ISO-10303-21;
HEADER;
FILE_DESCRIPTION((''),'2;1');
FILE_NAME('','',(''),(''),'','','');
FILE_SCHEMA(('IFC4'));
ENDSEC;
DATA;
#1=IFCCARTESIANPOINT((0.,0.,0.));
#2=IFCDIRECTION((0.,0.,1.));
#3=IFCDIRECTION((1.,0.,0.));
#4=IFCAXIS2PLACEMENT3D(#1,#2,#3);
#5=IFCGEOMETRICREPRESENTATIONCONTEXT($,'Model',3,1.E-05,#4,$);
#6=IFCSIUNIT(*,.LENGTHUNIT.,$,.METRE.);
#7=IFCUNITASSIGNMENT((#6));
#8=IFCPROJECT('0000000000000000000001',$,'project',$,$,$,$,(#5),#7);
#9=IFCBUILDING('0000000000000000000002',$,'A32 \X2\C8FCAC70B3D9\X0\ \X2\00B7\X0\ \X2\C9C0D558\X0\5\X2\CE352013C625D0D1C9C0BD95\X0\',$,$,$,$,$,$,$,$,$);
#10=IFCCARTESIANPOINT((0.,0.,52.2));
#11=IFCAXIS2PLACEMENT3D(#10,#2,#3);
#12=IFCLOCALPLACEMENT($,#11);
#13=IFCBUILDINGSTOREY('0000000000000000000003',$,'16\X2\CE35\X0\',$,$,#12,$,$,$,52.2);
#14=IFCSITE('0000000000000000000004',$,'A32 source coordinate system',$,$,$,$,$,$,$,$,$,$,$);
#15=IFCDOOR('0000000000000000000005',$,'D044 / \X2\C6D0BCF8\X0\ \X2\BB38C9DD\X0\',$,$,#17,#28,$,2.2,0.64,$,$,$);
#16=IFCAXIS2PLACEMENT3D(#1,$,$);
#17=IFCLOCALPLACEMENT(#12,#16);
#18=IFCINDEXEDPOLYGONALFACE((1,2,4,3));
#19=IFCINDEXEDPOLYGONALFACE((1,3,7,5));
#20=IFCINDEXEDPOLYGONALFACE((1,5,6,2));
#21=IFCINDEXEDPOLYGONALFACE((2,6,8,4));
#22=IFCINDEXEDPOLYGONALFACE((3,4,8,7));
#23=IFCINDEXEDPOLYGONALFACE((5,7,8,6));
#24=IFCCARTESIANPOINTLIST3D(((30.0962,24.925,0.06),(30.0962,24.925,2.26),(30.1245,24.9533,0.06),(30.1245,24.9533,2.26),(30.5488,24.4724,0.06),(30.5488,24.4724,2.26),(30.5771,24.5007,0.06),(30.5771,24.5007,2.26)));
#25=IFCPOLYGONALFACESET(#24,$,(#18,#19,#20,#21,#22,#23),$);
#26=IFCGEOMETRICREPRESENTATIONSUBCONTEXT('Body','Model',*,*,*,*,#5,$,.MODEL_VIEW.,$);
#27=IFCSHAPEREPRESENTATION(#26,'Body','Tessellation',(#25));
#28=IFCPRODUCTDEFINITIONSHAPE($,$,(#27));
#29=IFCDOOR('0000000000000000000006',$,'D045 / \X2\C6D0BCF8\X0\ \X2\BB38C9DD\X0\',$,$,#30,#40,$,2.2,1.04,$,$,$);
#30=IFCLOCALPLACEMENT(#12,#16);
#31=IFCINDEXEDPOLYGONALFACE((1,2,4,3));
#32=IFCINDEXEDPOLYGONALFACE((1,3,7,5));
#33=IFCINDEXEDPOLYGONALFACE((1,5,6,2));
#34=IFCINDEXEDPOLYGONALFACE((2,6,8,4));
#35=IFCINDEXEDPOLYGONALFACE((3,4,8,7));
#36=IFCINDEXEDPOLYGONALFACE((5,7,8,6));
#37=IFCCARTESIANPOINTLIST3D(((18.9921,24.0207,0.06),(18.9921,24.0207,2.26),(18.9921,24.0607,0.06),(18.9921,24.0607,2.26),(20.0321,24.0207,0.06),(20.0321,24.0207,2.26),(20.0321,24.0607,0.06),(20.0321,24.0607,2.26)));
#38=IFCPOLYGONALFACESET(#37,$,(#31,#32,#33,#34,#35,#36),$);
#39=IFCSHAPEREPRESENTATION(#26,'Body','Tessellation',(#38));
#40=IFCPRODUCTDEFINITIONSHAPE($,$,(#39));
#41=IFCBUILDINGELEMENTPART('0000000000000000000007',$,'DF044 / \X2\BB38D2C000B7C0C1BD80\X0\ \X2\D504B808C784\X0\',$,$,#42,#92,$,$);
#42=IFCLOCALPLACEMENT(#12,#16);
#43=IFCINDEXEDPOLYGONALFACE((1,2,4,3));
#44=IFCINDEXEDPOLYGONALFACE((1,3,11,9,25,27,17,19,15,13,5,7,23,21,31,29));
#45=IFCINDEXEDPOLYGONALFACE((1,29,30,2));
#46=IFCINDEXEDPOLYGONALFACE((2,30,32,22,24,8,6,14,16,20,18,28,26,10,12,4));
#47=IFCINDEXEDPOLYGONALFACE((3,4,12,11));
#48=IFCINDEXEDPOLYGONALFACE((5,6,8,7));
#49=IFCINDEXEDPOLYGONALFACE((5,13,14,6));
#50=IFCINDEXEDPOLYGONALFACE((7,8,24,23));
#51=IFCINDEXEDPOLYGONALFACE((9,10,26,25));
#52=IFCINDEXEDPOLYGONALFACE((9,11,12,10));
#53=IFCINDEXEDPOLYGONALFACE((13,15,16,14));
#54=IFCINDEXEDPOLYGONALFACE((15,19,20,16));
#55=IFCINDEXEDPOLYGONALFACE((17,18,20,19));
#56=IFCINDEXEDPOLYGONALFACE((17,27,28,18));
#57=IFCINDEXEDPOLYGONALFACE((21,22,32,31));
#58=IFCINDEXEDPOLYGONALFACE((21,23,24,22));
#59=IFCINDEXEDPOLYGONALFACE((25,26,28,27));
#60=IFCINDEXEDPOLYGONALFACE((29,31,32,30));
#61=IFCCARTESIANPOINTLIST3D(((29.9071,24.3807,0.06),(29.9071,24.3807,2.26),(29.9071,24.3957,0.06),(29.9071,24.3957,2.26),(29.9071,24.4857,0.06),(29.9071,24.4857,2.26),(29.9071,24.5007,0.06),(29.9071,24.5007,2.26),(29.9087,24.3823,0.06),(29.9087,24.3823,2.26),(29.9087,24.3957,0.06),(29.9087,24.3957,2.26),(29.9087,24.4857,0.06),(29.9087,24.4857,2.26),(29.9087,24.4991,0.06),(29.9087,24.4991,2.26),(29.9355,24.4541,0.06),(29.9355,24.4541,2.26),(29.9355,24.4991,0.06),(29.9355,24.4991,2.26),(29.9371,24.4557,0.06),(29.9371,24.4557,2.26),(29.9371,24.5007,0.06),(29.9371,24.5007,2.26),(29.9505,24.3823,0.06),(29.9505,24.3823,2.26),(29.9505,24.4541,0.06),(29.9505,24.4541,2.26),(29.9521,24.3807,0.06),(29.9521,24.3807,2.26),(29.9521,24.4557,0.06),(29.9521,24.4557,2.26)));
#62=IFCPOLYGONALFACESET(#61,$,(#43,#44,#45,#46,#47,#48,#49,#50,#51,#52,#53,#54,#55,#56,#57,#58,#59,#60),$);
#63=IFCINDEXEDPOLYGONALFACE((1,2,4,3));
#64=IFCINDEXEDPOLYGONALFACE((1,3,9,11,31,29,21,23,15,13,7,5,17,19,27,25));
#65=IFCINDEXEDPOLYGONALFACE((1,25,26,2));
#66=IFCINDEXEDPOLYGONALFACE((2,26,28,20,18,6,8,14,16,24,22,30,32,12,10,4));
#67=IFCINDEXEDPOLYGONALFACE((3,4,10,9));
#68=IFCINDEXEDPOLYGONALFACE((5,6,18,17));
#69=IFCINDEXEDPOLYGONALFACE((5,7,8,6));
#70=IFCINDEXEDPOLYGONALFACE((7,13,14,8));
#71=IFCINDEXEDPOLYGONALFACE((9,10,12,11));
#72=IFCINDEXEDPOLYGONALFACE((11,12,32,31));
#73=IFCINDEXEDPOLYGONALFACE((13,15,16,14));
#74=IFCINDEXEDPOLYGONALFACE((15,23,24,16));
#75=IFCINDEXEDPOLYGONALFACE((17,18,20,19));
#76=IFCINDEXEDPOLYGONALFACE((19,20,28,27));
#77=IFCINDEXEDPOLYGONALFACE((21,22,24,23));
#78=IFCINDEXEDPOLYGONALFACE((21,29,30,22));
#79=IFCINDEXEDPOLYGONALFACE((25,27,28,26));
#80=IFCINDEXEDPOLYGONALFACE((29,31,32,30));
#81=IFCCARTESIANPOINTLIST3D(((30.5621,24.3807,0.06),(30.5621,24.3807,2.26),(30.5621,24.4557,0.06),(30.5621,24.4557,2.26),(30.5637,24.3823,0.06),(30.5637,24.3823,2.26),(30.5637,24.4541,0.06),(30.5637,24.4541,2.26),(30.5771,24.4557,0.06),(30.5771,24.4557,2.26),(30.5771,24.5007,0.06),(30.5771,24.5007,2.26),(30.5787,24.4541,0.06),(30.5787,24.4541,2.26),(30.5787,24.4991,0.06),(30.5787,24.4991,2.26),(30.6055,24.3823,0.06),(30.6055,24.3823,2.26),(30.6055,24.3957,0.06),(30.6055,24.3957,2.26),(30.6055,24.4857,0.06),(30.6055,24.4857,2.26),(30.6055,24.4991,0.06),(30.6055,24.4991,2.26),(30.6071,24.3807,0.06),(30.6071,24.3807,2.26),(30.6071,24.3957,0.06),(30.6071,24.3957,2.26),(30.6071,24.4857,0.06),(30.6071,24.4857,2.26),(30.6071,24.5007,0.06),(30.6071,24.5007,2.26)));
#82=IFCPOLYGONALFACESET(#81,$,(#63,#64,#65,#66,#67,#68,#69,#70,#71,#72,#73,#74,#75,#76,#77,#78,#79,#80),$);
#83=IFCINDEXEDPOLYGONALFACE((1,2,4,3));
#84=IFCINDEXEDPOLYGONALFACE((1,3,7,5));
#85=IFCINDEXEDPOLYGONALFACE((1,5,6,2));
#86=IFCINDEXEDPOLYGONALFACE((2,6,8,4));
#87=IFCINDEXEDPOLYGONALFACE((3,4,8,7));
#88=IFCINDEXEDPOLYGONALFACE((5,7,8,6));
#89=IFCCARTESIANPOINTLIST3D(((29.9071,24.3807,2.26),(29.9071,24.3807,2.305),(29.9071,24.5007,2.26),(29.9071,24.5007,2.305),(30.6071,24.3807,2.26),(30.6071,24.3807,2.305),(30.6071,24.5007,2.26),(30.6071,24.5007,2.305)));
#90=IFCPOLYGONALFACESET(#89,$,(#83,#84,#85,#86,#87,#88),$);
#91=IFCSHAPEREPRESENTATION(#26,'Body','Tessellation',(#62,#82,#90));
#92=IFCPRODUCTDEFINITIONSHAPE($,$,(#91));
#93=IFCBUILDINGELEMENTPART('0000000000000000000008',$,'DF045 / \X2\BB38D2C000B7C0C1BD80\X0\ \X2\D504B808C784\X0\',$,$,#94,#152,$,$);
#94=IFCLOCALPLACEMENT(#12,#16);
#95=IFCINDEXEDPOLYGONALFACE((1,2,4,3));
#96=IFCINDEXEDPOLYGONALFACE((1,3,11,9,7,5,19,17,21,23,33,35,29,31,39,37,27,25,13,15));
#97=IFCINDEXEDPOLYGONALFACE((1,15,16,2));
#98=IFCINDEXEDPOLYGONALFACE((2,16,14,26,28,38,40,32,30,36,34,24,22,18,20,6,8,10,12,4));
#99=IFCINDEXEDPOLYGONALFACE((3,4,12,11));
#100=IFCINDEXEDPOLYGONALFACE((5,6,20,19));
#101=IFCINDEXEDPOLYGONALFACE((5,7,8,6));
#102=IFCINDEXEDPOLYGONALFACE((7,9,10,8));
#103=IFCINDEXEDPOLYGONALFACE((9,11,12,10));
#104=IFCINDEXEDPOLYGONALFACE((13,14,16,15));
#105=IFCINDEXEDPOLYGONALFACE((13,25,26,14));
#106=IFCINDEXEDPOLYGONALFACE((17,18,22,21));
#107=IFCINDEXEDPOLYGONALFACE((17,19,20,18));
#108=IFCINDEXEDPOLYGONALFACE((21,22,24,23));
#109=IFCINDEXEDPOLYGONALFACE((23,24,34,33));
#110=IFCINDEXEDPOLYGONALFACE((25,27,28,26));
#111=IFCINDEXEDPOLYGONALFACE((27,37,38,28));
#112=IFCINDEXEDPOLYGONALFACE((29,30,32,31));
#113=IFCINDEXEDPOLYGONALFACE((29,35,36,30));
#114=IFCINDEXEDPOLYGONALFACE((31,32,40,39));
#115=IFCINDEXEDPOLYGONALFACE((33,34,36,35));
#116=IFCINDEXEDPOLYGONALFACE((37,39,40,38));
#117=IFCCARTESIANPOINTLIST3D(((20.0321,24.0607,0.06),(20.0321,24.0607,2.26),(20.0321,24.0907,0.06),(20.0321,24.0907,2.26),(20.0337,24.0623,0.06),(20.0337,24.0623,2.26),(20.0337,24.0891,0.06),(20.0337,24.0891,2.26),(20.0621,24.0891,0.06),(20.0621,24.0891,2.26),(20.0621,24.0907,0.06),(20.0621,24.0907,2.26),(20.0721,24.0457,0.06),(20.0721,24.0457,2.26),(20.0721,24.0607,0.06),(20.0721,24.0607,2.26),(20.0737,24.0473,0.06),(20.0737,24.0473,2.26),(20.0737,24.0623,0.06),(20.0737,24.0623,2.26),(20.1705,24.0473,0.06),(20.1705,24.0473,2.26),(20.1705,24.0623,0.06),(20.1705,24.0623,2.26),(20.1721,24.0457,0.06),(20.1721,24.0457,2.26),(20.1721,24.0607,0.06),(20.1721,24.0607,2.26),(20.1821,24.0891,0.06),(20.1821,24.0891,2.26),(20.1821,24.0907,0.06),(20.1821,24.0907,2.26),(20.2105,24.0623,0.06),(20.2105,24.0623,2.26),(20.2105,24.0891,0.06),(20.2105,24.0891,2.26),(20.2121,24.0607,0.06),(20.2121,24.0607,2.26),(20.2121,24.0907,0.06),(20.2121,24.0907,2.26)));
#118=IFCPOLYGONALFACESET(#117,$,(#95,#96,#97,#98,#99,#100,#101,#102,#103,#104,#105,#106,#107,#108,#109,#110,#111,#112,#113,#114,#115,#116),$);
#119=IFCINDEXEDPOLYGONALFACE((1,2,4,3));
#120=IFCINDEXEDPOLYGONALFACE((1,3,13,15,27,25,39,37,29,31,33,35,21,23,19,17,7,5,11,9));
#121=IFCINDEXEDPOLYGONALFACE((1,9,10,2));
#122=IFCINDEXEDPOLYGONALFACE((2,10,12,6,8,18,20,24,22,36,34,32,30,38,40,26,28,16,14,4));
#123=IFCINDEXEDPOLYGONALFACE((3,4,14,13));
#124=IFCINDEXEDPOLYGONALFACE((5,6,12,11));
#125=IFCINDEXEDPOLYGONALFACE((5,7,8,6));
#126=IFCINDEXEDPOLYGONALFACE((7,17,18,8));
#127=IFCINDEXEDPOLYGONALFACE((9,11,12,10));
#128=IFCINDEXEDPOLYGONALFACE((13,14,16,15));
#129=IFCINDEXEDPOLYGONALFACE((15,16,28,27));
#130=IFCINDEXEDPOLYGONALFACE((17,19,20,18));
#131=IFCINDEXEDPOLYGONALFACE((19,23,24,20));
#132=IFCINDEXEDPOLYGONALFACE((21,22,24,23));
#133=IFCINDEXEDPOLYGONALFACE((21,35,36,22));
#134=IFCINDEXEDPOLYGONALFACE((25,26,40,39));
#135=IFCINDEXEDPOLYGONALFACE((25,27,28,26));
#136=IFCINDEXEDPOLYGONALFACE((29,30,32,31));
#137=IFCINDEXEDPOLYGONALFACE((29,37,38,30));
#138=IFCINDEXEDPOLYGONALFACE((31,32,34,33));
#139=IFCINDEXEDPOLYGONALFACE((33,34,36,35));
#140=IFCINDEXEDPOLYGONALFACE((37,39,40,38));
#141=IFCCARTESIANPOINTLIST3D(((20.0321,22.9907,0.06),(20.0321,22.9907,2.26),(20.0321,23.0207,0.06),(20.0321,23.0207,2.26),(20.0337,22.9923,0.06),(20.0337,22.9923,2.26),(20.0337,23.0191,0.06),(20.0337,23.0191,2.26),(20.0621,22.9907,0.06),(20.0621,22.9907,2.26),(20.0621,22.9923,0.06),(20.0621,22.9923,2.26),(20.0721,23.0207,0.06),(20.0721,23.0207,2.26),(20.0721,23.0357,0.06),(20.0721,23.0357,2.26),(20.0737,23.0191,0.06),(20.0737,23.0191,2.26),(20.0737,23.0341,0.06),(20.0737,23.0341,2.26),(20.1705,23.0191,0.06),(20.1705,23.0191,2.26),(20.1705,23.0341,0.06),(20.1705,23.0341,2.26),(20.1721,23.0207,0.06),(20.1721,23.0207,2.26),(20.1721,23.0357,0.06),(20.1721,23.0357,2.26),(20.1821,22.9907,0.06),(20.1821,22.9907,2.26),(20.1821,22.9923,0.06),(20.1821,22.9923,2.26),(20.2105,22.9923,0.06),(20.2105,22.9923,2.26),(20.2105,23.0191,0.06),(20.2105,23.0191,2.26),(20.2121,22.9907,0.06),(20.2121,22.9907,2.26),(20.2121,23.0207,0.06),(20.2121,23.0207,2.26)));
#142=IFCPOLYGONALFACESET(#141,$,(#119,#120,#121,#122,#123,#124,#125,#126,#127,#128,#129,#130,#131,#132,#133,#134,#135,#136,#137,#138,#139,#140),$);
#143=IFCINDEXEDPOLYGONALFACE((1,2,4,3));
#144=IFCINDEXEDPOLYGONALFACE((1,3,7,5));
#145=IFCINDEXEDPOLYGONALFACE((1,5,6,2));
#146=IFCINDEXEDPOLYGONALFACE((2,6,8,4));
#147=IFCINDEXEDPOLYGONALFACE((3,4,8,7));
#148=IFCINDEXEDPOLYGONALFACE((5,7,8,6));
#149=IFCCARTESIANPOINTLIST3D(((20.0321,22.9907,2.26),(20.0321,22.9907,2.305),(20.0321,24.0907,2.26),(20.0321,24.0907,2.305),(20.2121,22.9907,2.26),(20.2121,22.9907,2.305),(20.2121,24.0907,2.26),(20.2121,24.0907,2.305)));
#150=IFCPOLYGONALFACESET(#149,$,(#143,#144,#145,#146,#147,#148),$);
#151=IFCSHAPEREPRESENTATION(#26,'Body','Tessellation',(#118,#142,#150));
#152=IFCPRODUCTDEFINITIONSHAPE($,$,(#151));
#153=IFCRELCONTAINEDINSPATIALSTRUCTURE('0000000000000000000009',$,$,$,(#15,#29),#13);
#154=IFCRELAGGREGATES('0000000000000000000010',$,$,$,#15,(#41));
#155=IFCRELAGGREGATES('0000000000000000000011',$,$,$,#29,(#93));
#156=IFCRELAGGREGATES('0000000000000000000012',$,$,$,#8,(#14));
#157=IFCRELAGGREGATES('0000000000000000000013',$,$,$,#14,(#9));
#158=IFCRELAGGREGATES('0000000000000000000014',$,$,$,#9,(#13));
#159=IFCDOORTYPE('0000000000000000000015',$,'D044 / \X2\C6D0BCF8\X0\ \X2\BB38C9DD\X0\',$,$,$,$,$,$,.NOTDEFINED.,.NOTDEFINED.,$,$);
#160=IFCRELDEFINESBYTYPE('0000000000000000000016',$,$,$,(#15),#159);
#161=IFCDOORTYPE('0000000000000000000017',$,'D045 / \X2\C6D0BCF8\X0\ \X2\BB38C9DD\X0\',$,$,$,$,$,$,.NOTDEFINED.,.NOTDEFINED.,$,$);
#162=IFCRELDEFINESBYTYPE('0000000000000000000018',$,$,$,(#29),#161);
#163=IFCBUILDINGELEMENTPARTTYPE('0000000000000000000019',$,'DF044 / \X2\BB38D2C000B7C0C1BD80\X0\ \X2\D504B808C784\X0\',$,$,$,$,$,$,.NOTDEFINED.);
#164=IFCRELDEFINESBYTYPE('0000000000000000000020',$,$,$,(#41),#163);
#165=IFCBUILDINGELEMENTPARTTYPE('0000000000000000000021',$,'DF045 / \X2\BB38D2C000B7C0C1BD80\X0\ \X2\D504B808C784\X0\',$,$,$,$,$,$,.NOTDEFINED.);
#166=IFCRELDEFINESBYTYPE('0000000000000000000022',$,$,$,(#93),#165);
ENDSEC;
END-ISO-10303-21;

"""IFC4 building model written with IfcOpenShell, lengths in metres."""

from ifc_helpers import new_model, si_unit, frame, origin, origin_with_axes, place, context, subcontext, project, spatial, polyline, outline, extrude, source, transform, mapped, type_object, type_shapes, element, aggregate, save


model = new_model("IFC4")

# Units and contexts
model_context = context("Model", 3, precision=1e-05, world=origin_with_axes())
body_context = subcontext(model_context, "Body", "Model", "MODEL_VIEW")
ifc_project = project(units=[si_unit("LENGTHUNIT", "METRE")], contexts=[model_context])

# Site, building, storey
storey_placement = place(None, frame((0.0, 0.0, 52.2), z_axis=(0.0, 0.0, 1.0), x_axis=(1.0, 0.0, 0.0)))
site = spatial("IfcSite", under=ifc_project, Name="A32 source coordinate system")
building = spatial("IfcBuilding", under=site, Name="A32 주거동 · 지하5층–옥탑지붕")
storey = spatial("IfcBuildingStorey", under=building, at=storey_placement, Name="16층", Elevation=52.2)

# Doors
door_type_1 = type_object("IfcDoorType", Name="D044 / 원본 문짝", OperationType="NOTDEFINED", PredefinedType="NOTDEFINED")
shared_shape_1 = source(origin(), body_context, "Body", "SweptSolid", [
    extrude(outline(polyline([(30.5771, 24.5007), (30.5488, 24.4724), (30.0962, 24.925), (30.1245, 24.9533), (30.5771, 24.5007)])), frame((0.0, 0.0, 0.06)), (0.0, 0.0, 1.0), 2.2),
])
type_shapes(door_type_1, [shared_shape_1])
door_1_placement = place(storey_placement, origin_with_axes())
door_1 = element("IfcDoor", 1, at=door_1_placement, inside=storey, type_object=door_type_1, Name="D044 / 원본 문짝", OverallHeight=2.2, OverallWidth=0.64, context=body_context, shape_type="MappedRepresentation", body=[
    mapped(shared_shape_1, transform((0.0, 0.0, 0.0), scale=1.0)),
])
door_type_2 = type_object("IfcDoorType", Name="D045 / 원본 문짝", OperationType="NOTDEFINED", PredefinedType="NOTDEFINED")
shared_shape_2 = source(origin(), body_context, "Body", "SweptSolid", [
    extrude(outline(polyline([(20.0321, 24.0607), (20.0321, 24.0207), (18.9921, 24.0207), (18.9921, 24.0607), (20.0321, 24.0607)])), frame((0.0, 0.0, 0.06)), (0.0, 0.0, 1.0), 2.2),
])
type_shapes(door_type_2, [shared_shape_2])
door_2_placement = place(storey_placement, origin_with_axes())
door_2 = element("IfcDoor", 2, at=door_2_placement, inside=storey, type_object=door_type_2, Name="D045 / 원본 문짝", OverallHeight=2.2, OverallWidth=1.04, context=body_context, shape_type="MappedRepresentation", body=[
    mapped(shared_shape_2, transform((0.0, 0.0, 0.0), scale=1.0)),
])

# Building element parts
building_element_part_type_1 = type_object("IfcBuildingElementPartType", Name="DF044 / 문틀·상부 프레임", PredefinedType="NOTDEFINED")
shared_shape_3 = source(origin(), body_context, "Body", "SweptSolid", [
    extrude(outline(polyline([(29.9071, 24.4857), (29.9071, 24.5007), (29.9371, 24.5007), (29.9371, 24.4557), (29.9521, 24.4557), (29.9521, 24.3807), (29.9071, 24.3807), (29.9071, 24.3957), (29.9087, 24.3957), (29.9087, 24.3823), (29.9505, 24.3823), (29.9505, 24.4541), (29.9355, 24.4541), (29.9355, 24.4991), (29.9087, 24.4991), (29.9087, 24.4857), (29.9071, 24.4857)])), frame((0.0, 0.0, 0.06)), (0.0, 0.0, 1.0), 2.2),
    extrude(outline(polyline([(30.6055, 24.4991), (30.5787, 24.4991), (30.5787, 24.4541), (30.5637, 24.4541), (30.5637, 24.3823), (30.6055, 24.3823), (30.6055, 24.3957), (30.6071, 24.3957), (30.6071, 24.3807), (30.5621, 24.3807), (30.5621, 24.4557), (30.5771, 24.4557), (30.5771, 24.5007), (30.6071, 24.5007), (30.6071, 24.4857), (30.6055, 24.4857), (30.6055, 24.4991)])), frame((0.0, 0.0, 0.06)), (0.0, 0.0, 1.0), 2.2),
    extrude(outline(polyline([(29.9071, 24.3807), (29.9071, 24.5007), (30.6071, 24.5007), (30.6071, 24.3807), (29.9071, 24.3807)])), frame((0.0, 0.0, 2.26)), (0.0, 0.0, 1.0), 0.045),
])
type_shapes(building_element_part_type_1, [shared_shape_3])
building_element_part_1_placement = place(door_1_placement, origin_with_axes())
building_element_part_1 = element("IfcBuildingElementPart", 3, at=building_element_part_1_placement, type_object=building_element_part_type_1, Name="DF044 / 문틀·상부 프레임", context=body_context, shape_type="MappedRepresentation", body=[
    mapped(shared_shape_3, transform((0.0, 0.0, 0.0), scale=1.0)),
])
aggregate(door_1, [building_element_part_1])
building_element_part_type_2 = type_object("IfcBuildingElementPartType", Name="DF045 / 문틀·상부 프레임", PredefinedType="NOTDEFINED")
shared_shape_4 = source(origin(), body_context, "Body", "SweptSolid", [
    extrude(outline(polyline([(20.0337, 24.0891), (20.0337, 24.0623), (20.0737, 24.0623), (20.0737, 24.0473), (20.1705, 24.0473), (20.1705, 24.0623), (20.2105, 24.0623), (20.2105, 24.0891), (20.1821, 24.0891), (20.1821, 24.0907), (20.2121, 24.0907), (20.2121, 24.0607), (20.1721, 24.0607), (20.1721, 24.0457), (20.0721, 24.0457), (20.0721, 24.0607), (20.0321, 24.0607), (20.0321, 24.0907), (20.0621, 24.0907), (20.0621, 24.0891), (20.0337, 24.0891)])), frame((0.0, 0.0, 0.06)), (0.0, 0.0, 1.0), 2.2),
    extrude(outline(polyline([(20.0621, 22.9907), (20.0321, 22.9907), (20.0321, 23.0207), (20.0721, 23.0207), (20.0721, 23.0357), (20.1721, 23.0357), (20.1721, 23.0207), (20.2121, 23.0207), (20.2121, 22.9907), (20.1821, 22.9907), (20.1821, 22.9923), (20.2105, 22.9923), (20.2105, 23.0191), (20.1705, 23.0191), (20.1705, 23.0341), (20.0737, 23.0341), (20.0737, 23.0191), (20.0337, 23.0191), (20.0337, 22.9923), (20.0621, 22.9923), (20.0621, 22.9907)])), frame((0.0, 0.0, 0.06)), (0.0, 0.0, 1.0), 2.2),
    extrude(outline(polyline([(20.0321, 22.9907), (20.0321, 24.0907), (20.2121, 24.0907), (20.2121, 22.9907), (20.0321, 22.9907)])), frame((0.0, 0.0, 2.26)), (0.0, 0.0, 1.0), 0.045),
])
type_shapes(building_element_part_type_2, [shared_shape_4])
building_element_part_2_placement = place(door_2_placement, origin_with_axes())
building_element_part_2 = element("IfcBuildingElementPart", 4, at=building_element_part_2_placement, type_object=building_element_part_type_2, Name="DF045 / 문틀·상부 프레임", context=body_context, shape_type="MappedRepresentation", body=[
    mapped(shared_shape_4, transform((0.0, 0.0, 0.0), scale=1.0)),
])
aggregate(door_2, [building_element_part_2])

save(model, "model.ifc")
